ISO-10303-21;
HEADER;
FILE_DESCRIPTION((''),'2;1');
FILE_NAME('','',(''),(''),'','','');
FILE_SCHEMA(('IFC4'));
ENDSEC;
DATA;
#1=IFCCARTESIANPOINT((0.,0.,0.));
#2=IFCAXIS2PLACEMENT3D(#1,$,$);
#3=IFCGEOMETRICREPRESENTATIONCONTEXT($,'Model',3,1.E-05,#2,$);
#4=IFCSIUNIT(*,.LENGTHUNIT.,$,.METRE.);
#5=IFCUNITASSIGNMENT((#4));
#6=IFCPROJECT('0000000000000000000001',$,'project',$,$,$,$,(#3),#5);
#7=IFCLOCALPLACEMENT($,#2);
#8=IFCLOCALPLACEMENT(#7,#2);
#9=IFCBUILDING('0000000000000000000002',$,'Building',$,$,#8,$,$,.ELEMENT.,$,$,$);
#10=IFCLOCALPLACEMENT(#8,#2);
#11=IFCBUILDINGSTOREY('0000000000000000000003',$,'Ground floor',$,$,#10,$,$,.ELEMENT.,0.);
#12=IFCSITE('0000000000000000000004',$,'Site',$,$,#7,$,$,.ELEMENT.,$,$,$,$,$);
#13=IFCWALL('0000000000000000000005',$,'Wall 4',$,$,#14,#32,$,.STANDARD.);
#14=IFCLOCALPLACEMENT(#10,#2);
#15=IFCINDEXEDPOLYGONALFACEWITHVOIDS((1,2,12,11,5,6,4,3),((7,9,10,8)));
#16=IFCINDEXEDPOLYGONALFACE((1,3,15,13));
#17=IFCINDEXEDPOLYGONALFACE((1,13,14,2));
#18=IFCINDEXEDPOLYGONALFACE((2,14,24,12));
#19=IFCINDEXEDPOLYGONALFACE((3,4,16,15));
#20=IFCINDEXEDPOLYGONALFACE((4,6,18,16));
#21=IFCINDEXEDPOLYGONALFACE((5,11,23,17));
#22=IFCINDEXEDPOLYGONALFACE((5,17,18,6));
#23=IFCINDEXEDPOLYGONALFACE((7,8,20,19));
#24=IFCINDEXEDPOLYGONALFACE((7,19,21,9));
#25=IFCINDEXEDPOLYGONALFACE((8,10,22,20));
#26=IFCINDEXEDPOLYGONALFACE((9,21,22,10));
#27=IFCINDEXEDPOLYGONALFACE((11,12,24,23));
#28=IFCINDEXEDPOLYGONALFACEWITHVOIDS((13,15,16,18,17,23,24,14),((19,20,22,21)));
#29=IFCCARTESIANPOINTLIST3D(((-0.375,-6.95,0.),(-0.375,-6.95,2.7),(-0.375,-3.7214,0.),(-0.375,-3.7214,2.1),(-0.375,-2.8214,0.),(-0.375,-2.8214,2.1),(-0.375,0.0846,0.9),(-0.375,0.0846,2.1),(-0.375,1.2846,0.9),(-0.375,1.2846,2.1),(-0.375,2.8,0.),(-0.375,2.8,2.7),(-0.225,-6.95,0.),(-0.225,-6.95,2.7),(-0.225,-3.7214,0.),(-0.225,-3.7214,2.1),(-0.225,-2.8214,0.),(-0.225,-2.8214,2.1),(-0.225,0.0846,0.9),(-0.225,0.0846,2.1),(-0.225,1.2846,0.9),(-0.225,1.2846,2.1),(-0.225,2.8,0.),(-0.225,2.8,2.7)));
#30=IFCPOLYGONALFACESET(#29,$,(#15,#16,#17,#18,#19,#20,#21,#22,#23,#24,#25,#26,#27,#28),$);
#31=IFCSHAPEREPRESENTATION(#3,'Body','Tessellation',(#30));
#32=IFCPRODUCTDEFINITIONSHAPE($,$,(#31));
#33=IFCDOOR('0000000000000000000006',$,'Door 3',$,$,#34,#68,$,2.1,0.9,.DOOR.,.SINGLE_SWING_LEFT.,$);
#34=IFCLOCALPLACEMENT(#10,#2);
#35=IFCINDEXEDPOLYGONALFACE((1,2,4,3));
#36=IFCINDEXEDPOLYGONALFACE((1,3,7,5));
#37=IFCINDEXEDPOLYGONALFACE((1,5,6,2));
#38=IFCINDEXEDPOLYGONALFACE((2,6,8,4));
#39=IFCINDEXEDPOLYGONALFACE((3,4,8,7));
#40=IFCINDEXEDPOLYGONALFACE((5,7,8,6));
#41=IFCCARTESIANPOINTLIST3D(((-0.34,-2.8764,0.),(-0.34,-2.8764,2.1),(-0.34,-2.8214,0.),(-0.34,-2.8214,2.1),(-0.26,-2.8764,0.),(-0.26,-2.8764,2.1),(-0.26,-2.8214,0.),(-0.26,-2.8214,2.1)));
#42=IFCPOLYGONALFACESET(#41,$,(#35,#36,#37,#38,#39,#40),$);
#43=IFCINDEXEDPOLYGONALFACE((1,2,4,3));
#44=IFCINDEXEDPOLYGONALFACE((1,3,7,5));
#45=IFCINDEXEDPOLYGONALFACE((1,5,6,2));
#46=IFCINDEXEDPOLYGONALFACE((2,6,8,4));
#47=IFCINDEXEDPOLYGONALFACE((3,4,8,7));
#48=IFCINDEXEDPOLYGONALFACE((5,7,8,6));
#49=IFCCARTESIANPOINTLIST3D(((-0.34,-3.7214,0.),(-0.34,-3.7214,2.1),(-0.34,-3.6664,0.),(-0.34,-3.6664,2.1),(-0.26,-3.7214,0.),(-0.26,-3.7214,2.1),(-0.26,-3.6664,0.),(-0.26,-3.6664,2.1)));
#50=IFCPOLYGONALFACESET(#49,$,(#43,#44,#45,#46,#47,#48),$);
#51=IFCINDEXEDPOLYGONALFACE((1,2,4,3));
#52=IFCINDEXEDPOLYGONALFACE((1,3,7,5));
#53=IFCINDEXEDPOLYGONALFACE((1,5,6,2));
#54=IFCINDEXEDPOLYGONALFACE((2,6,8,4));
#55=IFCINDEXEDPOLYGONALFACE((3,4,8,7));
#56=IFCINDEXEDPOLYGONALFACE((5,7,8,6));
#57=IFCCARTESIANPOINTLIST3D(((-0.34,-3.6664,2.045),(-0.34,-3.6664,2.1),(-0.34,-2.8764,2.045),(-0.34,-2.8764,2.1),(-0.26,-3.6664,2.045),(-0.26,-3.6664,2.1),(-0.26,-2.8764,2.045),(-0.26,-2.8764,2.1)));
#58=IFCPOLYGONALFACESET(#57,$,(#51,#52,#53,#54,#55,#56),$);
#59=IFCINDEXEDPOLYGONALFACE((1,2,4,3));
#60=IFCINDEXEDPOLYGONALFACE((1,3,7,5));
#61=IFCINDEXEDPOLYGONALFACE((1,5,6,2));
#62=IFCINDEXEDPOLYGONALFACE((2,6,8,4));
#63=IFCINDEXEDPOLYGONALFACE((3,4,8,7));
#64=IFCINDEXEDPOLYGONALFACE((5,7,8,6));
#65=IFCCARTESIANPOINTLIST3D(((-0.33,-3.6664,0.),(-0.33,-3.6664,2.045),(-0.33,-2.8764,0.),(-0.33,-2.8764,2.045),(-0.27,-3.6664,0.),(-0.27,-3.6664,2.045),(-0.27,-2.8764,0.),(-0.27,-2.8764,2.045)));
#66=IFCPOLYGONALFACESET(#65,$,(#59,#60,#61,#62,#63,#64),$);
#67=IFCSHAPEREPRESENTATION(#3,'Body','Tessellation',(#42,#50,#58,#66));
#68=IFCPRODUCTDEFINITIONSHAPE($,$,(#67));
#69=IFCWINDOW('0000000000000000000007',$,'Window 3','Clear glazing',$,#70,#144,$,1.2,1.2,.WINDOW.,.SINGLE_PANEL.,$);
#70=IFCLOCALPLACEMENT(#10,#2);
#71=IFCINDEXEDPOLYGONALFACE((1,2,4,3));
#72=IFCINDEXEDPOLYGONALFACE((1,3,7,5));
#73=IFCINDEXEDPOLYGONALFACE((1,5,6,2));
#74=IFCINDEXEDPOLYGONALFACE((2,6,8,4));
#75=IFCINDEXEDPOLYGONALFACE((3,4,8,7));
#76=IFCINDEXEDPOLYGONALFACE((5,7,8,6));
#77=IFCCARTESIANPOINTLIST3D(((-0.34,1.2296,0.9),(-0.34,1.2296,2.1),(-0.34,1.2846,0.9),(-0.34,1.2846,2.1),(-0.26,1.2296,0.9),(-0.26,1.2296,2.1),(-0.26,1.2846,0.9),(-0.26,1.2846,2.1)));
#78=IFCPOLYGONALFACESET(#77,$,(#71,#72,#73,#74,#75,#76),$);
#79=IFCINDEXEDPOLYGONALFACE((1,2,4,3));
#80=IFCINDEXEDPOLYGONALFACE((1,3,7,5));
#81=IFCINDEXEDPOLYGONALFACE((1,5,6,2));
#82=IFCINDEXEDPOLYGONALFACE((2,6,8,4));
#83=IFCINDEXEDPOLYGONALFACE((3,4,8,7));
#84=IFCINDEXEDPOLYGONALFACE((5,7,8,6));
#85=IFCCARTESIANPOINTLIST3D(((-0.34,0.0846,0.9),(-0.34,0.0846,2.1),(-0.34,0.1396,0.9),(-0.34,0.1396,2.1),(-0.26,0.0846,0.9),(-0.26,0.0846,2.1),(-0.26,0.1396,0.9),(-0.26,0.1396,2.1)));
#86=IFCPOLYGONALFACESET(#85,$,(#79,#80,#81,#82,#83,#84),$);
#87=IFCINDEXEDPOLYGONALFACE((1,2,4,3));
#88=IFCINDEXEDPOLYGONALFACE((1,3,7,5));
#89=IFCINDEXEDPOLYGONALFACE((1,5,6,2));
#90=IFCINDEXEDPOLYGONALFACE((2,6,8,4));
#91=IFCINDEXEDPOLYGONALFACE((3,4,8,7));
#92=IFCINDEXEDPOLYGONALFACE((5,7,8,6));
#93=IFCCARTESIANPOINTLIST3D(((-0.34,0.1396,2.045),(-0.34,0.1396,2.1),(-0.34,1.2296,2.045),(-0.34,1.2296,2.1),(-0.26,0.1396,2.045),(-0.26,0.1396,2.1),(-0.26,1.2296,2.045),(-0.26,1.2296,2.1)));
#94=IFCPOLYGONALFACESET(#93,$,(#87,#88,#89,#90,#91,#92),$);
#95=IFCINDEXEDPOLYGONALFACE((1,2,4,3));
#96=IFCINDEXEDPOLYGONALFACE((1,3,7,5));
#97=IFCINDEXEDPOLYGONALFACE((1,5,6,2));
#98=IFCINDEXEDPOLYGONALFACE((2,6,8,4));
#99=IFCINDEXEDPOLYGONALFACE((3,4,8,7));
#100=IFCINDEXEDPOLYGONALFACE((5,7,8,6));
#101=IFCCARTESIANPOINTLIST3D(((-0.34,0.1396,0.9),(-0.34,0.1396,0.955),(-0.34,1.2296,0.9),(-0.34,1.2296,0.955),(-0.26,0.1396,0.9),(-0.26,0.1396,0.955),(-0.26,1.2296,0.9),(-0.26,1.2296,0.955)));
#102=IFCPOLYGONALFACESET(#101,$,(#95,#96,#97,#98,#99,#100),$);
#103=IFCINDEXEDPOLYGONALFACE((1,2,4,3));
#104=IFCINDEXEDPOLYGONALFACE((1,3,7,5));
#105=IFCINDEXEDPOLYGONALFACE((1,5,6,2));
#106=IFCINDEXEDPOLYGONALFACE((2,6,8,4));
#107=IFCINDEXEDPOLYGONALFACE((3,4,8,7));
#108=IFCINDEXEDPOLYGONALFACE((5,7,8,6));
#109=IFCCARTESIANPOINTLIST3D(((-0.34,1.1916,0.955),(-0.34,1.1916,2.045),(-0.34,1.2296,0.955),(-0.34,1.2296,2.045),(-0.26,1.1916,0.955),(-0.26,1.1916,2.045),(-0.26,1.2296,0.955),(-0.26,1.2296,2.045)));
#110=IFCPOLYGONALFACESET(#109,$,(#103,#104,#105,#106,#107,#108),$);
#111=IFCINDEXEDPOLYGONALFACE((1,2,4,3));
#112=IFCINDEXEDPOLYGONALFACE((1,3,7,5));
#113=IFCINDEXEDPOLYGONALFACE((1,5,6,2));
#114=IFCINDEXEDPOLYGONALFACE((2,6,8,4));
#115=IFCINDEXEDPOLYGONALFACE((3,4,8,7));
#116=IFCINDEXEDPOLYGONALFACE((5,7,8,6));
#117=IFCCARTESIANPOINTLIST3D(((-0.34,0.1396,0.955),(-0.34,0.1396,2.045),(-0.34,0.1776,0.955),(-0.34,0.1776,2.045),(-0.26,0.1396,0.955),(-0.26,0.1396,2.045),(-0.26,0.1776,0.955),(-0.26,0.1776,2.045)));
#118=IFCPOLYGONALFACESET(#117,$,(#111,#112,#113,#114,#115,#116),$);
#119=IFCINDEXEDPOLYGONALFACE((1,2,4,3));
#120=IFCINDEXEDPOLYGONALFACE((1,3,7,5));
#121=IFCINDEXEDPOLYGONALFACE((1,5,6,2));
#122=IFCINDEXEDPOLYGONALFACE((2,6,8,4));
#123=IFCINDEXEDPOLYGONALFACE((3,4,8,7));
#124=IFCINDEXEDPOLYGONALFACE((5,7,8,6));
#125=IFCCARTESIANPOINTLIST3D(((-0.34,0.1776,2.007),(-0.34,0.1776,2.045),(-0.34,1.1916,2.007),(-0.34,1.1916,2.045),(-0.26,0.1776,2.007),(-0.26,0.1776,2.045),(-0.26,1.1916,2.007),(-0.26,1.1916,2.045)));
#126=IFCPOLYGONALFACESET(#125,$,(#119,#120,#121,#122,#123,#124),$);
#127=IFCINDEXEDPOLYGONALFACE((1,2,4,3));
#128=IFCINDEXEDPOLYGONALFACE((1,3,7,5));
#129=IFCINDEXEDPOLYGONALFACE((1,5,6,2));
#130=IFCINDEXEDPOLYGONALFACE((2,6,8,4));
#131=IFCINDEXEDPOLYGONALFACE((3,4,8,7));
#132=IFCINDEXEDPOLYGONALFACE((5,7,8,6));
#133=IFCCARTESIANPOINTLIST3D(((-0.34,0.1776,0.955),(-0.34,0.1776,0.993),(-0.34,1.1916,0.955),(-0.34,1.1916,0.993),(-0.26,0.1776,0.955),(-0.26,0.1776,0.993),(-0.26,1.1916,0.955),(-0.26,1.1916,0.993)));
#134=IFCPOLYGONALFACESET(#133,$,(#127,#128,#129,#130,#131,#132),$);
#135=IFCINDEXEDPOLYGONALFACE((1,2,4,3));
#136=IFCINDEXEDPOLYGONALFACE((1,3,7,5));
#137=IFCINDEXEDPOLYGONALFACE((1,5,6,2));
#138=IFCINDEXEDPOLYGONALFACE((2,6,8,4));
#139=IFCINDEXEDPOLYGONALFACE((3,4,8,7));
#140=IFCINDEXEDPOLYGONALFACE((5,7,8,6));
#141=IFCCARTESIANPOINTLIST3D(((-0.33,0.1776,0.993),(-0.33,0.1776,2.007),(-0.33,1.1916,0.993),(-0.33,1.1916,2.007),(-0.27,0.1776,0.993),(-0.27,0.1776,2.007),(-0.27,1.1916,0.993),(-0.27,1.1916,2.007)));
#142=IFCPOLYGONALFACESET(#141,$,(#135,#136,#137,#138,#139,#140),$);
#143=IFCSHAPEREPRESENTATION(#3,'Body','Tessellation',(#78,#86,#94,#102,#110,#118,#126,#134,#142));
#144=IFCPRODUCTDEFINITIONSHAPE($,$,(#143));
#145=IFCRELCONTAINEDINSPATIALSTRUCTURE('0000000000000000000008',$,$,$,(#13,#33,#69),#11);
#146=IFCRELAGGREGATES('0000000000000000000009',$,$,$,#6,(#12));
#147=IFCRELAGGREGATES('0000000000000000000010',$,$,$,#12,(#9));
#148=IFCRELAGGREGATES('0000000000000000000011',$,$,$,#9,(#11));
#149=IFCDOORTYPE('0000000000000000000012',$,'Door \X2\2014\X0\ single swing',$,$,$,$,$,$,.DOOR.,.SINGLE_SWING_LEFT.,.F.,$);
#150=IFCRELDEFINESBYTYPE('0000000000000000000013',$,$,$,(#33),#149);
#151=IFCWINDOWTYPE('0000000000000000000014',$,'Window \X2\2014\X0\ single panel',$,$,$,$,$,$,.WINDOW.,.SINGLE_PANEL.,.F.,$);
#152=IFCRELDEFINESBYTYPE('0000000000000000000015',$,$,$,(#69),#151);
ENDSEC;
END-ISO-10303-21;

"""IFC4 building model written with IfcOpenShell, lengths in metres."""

from ifc_helpers import new_model, si_unit, frame, frame_2d, origin, place, context, project, spatial, rectangle, extrude, type_object, element, fill, save


model = new_model("IFC4")

# Units and contexts
model_context = context("Model", 3, precision=1e-05, world=origin())
ifc_project = project(units=[si_unit("LENGTHUNIT", "METRE")], contexts=[model_context])

# Site, building, storey
site_placement = place(None, origin())
site = spatial("IfcSite", under=ifc_project, at=site_placement, Name="Site", CompositionType="ELEMENT")
building_placement = place(site_placement, origin())
building = spatial("IfcBuilding", under=site, at=building_placement, Name="Building", CompositionType="ELEMENT")
storey_placement = place(building_placement, origin())
storey = spatial("IfcBuildingStorey", under=building, at=storey_placement, Name="Ground floor", CompositionType="ELEMENT", Elevation=0.0)

# Shared definitions
door_type = type_object("IfcDoorType", Name="Door — single swing", OperationType="SINGLE_SWING_LEFT", ParameterTakesPrecedence=False, PredefinedType="DOOR")
window_type_1 = type_object("IfcWindowType", Name="Window — single panel", ParameterTakesPrecedence=False, PartitioningType="SINGLE_PANEL", PredefinedType="WINDOW")

# Wall, openings, door, window
wall_1_placement = place(storey_placement, frame((-0.3, 2.8, 0.0), z_axis=(0.0, 0.0, 1.0), x_axis=(0.0, -1.0, 0.0)))
wall_1 = element("IfcWall", 1, at=wall_1_placement, inside=storey, Name="Wall 4", PredefinedType="STANDARD", context=model_context, shape_type="SweptSolid", body=[
    extrude(rectangle(XDim=9.75, YDim=0.15, at=frame_2d((4.875, 0.0))), origin(), (0.0, 0.0, 1.0), 2.7),
])
opening_1_placement = place(storey_placement, frame((-0.3, 1.2846, 0.9), z_axis=(0.0, 0.0, 1.0), x_axis=(0.0, -1.0, 0.0)))
opening_1 = element("IfcOpeningElement", 2, at=opening_1_placement, cuts=wall_1, PredefinedType="OPENING", context=model_context, shape_type="SweptSolid", body=[
    extrude(rectangle(XDim=1.2, YDim=0.21, at=frame_2d((0.6, 0.0))), origin(), (0.0, 0.0, 1.0), 1.2),
])
opening_2_placement = place(storey_placement, frame((-0.3, -2.8214, 0.0), z_axis=(0.0, 0.0, 1.0), x_axis=(0.0, -1.0, 0.0)))
opening_2 = element("IfcOpeningElement", 3, at=opening_2_placement, cuts=wall_1, PredefinedType="OPENING", context=model_context, shape_type="SweptSolid", body=[
    extrude(rectangle(XDim=0.9, YDim=0.21, at=frame_2d((0.45, 0.0))), origin(), (0.0, 0.0, 1.0), 2.1),
])
door_1_placement = place(storey_placement, frame((-0.3, -2.8214, 0.0), z_axis=(0.0, 0.0, 1.0), x_axis=(0.0, -1.0, 0.0)))
door_1 = element("IfcDoor", 4, at=door_1_placement, inside=storey, type_object=door_type, Name="Door 3", OperationType="SINGLE_SWING_LEFT", OverallHeight=2.1, OverallWidth=0.9, PredefinedType="DOOR", context=model_context, shape_type="SweptSolid", body=[
    extrude(rectangle(XDim=0.055, YDim=0.08, at=frame_2d((0.0275, 0.0))), origin(), (0.0, 0.0, 1.0), 2.1),
    extrude(rectangle(XDim=0.055, YDim=0.08, at=frame_2d((0.8725, 0.0))), origin(), (0.0, 0.0, 1.0), 2.1),
    extrude(rectangle(XDim=0.79, YDim=0.08, at=frame_2d((0.45, 0.0))), frame((0.0, 0.0, 2.045)), (0.0, 0.0, 1.0), 0.055),
    extrude(rectangle(XDim=0.79, YDim=0.06, at=frame_2d((0.45, 0.0))), origin(), (0.0, 0.0, 1.0), 2.045),
])
fill(opening_2, door_1)
window_1_placement = place(storey_placement, frame((-0.3, 1.2846, 0.9), z_axis=(0.0, 0.0, 1.0), x_axis=(0.0, -1.0, 0.0)))
window_1 = element("IfcWindow", 5, at=window_1_placement, inside=storey, type_object=window_type_1, Name="Window 3", Description="Clear glazing", OverallHeight=1.2, OverallWidth=1.2, PartitioningType="SINGLE_PANEL", PredefinedType="WINDOW", context=model_context, shape_type="SweptSolid", body=[
    extrude(rectangle(XDim=0.055, YDim=0.08, at=frame_2d((0.0275, 0.0))), origin(), (0.0, 0.0, 1.0), 1.2),
    extrude(rectangle(XDim=0.055, YDim=0.08, at=frame_2d((1.1725, 0.0))), origin(), (0.0, 0.0, 1.0), 1.2),
    extrude(rectangle(XDim=1.09, YDim=0.08, at=frame_2d((0.6, 0.0))), frame((0.0, 0.0, 1.145)), (0.0, 0.0, 1.0), 0.055),
    extrude(rectangle(XDim=1.09, YDim=0.08, at=frame_2d((0.6, 0.0))), origin(), (0.0, 0.0, 1.0), 0.055),
    extrude(rectangle(XDim=0.038, YDim=0.08, at=frame_2d((0.074, 0.0))), frame((0.0, 0.0, 0.055)), (0.0, 0.0, 1.0), 1.09),
    extrude(rectangle(XDim=0.038, YDim=0.08, at=frame_2d((1.126, 0.0))), frame((0.0, 0.0, 0.055)), (0.0, 0.0, 1.0), 1.09),
    extrude(rectangle(XDim=1.014, YDim=0.08, at=frame_2d((0.6, 0.0))), frame((0.0, 0.0, 1.107)), (0.0, 0.0, 1.0), 0.038),
    extrude(rectangle(XDim=1.014, YDim=0.08, at=frame_2d((0.6, 0.0))), frame((0.0, 0.0, 0.055)), (0.0, 0.0, 1.0), 0.038),
    extrude(rectangle(XDim=1.014, YDim=0.06, at=frame_2d((0.6, 0.0))), frame((0.0, 0.0, 0.093)), (0.0, 0.0, 1.0), 1.014),
])
fill(opening_1, window_1)

save(model, "model.ifc")
